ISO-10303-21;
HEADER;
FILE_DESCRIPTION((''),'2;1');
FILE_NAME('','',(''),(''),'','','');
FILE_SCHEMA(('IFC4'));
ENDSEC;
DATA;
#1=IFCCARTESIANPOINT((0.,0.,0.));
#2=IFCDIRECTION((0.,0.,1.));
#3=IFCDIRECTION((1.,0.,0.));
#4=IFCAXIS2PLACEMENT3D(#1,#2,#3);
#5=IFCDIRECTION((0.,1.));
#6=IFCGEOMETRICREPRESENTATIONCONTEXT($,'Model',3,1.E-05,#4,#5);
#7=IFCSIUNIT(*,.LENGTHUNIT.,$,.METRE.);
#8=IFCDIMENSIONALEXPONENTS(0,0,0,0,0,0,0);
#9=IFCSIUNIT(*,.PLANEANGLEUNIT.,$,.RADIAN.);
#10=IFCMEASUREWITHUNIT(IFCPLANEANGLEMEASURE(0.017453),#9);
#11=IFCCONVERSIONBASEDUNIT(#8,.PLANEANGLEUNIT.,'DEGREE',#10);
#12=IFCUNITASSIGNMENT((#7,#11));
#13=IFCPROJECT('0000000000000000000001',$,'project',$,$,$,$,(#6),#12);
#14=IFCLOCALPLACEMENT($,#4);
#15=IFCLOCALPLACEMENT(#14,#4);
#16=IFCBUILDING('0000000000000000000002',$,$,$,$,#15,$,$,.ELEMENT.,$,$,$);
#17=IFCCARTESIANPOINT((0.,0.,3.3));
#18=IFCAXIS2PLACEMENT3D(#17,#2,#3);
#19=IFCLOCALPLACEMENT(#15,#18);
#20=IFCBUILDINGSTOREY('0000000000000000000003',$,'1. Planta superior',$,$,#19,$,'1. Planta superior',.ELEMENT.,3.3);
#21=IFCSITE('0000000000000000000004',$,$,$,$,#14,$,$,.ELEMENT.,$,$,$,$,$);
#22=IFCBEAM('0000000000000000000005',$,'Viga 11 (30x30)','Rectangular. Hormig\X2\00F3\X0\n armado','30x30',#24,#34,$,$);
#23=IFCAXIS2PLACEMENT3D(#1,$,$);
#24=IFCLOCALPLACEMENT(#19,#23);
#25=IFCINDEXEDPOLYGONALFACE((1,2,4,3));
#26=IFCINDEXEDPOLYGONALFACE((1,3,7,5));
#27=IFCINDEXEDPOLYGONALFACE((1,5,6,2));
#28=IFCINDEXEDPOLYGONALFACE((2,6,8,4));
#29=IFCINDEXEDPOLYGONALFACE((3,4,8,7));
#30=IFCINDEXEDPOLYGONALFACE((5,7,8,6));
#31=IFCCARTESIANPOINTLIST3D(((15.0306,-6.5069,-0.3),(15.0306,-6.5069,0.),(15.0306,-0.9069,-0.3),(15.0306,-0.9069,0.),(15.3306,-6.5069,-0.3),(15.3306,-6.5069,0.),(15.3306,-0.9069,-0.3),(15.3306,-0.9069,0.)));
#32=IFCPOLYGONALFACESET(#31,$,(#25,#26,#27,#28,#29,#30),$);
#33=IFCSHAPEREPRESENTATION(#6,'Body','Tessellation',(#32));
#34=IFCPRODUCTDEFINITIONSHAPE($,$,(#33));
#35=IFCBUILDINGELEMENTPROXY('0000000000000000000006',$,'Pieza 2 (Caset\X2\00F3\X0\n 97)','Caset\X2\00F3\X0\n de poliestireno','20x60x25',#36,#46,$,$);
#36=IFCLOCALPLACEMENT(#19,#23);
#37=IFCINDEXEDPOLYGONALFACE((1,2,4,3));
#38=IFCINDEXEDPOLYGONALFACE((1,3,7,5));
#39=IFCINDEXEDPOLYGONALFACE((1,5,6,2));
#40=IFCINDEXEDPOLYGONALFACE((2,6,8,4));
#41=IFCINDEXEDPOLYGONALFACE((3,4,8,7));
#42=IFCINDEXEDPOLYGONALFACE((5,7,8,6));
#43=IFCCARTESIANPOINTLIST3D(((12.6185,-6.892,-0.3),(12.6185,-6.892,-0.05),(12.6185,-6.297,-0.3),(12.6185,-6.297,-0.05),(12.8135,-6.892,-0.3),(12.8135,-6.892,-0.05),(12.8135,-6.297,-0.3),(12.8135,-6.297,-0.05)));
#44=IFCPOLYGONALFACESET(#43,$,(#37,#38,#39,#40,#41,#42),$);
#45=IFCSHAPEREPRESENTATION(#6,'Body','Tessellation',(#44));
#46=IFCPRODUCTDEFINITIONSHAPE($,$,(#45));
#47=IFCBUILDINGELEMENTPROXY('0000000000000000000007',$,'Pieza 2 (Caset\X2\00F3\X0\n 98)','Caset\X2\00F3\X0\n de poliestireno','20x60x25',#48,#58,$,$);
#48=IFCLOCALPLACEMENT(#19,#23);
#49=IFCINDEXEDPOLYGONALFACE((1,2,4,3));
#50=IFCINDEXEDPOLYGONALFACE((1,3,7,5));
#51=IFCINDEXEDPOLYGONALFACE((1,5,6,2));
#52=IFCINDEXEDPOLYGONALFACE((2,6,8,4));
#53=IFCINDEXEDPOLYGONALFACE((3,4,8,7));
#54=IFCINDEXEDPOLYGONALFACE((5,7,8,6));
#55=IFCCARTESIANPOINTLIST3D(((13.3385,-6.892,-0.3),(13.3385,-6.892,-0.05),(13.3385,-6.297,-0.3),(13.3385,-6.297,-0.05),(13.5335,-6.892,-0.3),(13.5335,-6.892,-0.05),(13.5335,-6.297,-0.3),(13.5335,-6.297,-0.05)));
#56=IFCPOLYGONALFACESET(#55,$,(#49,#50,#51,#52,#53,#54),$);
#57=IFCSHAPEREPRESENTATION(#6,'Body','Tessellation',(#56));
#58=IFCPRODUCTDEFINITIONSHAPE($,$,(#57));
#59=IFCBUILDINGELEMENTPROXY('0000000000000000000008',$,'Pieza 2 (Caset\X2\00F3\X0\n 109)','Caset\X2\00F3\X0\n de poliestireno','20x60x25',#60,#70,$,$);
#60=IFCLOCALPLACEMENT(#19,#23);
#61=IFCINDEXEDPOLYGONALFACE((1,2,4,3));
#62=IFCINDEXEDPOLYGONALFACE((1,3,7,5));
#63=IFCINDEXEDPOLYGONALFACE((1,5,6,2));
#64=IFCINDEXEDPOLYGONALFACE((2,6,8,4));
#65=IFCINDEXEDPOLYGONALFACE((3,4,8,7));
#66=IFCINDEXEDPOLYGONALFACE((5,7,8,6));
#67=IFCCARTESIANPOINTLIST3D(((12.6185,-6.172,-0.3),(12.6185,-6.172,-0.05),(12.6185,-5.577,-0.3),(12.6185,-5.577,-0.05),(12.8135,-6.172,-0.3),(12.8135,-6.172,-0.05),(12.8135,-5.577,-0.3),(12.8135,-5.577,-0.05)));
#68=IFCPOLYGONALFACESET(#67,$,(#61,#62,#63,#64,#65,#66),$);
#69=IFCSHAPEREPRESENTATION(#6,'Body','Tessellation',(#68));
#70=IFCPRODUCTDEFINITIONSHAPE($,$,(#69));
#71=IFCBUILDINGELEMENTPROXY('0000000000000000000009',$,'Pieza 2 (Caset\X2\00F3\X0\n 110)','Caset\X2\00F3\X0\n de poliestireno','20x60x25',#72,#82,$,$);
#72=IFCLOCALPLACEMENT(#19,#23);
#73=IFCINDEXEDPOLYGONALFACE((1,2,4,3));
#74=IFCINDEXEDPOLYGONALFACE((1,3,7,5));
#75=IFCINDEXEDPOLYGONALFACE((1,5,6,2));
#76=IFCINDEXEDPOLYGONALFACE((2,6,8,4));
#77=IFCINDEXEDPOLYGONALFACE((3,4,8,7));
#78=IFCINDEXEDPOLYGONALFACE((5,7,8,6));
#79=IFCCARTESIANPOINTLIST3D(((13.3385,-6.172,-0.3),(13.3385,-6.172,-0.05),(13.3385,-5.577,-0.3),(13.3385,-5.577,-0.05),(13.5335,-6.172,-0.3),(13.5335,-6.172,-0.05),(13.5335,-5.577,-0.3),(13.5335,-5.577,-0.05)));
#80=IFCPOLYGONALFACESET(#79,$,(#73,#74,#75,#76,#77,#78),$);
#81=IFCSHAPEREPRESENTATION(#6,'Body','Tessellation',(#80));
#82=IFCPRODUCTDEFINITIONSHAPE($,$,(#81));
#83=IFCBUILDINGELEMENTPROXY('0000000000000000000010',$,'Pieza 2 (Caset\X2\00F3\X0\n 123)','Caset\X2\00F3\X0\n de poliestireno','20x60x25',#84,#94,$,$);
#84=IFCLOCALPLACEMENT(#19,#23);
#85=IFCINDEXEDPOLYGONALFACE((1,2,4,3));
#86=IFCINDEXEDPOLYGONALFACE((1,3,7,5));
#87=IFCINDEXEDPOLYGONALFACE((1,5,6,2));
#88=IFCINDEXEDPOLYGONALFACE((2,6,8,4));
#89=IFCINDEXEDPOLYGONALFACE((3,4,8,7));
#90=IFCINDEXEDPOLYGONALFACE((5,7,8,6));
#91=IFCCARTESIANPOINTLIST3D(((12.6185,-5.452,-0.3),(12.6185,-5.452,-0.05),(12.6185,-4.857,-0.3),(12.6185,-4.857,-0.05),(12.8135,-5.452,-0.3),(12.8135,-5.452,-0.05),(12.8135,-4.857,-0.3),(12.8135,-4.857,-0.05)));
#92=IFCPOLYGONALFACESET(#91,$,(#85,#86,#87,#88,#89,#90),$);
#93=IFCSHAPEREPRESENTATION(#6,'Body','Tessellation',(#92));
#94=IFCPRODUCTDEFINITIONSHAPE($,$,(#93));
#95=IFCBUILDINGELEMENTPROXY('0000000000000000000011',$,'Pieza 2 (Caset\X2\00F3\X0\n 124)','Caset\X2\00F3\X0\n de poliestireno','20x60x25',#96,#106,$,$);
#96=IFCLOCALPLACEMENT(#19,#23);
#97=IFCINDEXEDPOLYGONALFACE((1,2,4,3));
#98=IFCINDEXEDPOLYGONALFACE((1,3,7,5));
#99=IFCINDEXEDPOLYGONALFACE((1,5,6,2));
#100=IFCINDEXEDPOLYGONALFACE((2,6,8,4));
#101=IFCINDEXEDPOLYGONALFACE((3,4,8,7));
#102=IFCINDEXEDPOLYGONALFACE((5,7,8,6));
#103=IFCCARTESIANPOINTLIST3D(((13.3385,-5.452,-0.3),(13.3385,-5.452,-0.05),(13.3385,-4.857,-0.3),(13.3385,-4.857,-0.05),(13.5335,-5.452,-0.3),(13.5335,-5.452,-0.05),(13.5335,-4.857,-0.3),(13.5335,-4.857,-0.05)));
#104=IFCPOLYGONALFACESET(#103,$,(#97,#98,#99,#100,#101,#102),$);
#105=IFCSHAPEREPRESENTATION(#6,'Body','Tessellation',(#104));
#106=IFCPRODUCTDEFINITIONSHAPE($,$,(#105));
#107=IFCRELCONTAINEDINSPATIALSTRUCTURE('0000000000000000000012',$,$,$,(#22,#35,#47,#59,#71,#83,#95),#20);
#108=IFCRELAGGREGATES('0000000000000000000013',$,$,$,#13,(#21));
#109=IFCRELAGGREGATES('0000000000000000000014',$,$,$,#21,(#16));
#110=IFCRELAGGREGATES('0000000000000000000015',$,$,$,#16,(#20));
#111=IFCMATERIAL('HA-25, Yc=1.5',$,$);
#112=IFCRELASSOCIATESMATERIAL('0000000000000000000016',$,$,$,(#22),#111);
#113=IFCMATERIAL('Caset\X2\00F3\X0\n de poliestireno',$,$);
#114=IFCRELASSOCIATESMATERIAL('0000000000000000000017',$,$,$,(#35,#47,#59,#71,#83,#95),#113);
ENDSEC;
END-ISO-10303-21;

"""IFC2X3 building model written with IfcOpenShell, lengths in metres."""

from ifc_helpers import new_model, entity, si_unit, converted_unit, direction, frame, frame_2d, origin_with_axes, origin_2d_with_axis, place, context, project, spatial, rectangle, extrude, source, transform, mapped, material, element, save


model = new_model("IFC2X3")

# Units and contexts
model_context = context("Model", 3, precision=1e-05, world=origin_with_axes(), true_north=direction((0.0, 1.0)))
ifc_project = project(units=[si_unit("LENGTHUNIT", "METRE"), converted_unit("PLANEANGLEUNIT", "DEGREE", entity("IfcPlaneAngleMeasure", 0.017453), si_unit("PLANEANGLEUNIT", "RADIAN"), dimensions=[0, 0, 0, 0, 0, 0, 0])], contexts=[model_context])

# Site, building, storey
site_placement = place(None, origin_with_axes())
site = spatial("IfcSite", under=ifc_project, at=site_placement, CompositionType="ELEMENT")
building_placement = place(site_placement, origin_with_axes())
building = spatial("IfcBuilding", under=site, at=building_placement, CompositionType="ELEMENT")
storey_placement = place(building_placement, frame((0.0, 0.0, 3.3), z_axis=(0.0, 0.0, 1.0), x_axis=(1.0, 0.0, 0.0)))
storey = spatial("IfcBuildingStorey", under=building, at=storey_placement, Name="1. Planta superior", LongName="1. Planta superior", CompositionType="ELEMENT", Elevation=3.3)

# Beam
ifc_material_1 = material(Name="HA-25, Yc=1.5")
beam_placement = place(storey_placement, frame((15.1806, -6.5069, 0.0), z_axis=(0.0, 1.0, 0.0), x_axis=(-1.0, 0.0, 0.0)))
element("IfcBeam", 1, at=beam_placement, inside=storey, material=ifc_material_1, Name="Viga 11 (30x30)", Description="Rectangular. Hormigón armado", ObjectType="30x30", context=model_context, shape_type="SweptSolid", body=[
    extrude(rectangle(XDim=0.3, YDim=0.3, at=frame_2d((0.0, -0.15), x_axis=(1.0, 0.0))), origin_with_axes(), (0.0, 0.0, 1.0), 5.6),
])

# Building element proxies
ifc_material_2 = material(Name="Casetón de poliestireno")
shared_shape = source(origin_with_axes(), model_context, "Body", "SweptSolid", [
    extrude(rectangle(XDim=0.195, YDim=0.25, at=origin_2d_with_axis()), origin_with_axes(), (0.0, 0.0, 1.0), 0.595),
])
placement_1 = place(storey_placement, frame((12.716, -6.892, -0.175), z_axis=(0.0, 1.0, 0.0), x_axis=(-1.0, 0.0, 0.0)))
for number, where, z_axis, x_axis, name in (
    (2, (0.0, 0.0, 0.0), (0.0, 0.0, 1.0), (1.0, 0.0, 0.0), "Pieza 2 (Casetón 97)"),
):
    element("IfcBuildingElementProxy", number, at=place(placement_1, frame(where, z_axis=z_axis, x_axis=x_axis)), inside=storey, material=ifc_material_2, Name=name, Description="Casetón de poliestireno", ObjectType="20x60x25", context=model_context, shape_type="MappedRepresentation", body=[
        mapped(shared_shape, transform((0.0, 0.0, 0.0), x_axis=(1.0, 0.0, 0.0), y_axis=(0.0, 1.0, 0.0), z_axis=(0.0, 0.0, 1.0))),
    ])
placement_2 = place(storey_placement, frame((13.436, -6.892, -0.175), z_axis=(0.0, 1.0, 0.0), x_axis=(-1.0, 0.0, 0.0)))
for number, where, z_axis, x_axis, name in (
    (3, (0.0, 0.0, 0.0), (0.0, 0.0, 1.0), (1.0, 0.0, 0.0), "Pieza 2 (Casetón 98)"),
):
    element("IfcBuildingElementProxy", number, at=place(placement_2, frame(where, z_axis=z_axis, x_axis=x_axis)), inside=storey, material=ifc_material_2, Name=name, Description="Casetón de poliestireno", ObjectType="20x60x25", context=model_context, shape_type="MappedRepresentation", body=[
        mapped(shared_shape, transform((0.0, 0.0, 0.0), x_axis=(1.0, 0.0, 0.0), y_axis=(0.0, 1.0, 0.0), z_axis=(0.0, 0.0, 1.0))),
    ])
placement_3 = place(storey_placement, frame((12.716, -6.172, -0.175), z_axis=(0.0, 1.0, 0.0), x_axis=(-1.0, 0.0, 0.0)))
for number, where, z_axis, x_axis, name in (
    (4, (0.0, 0.0, 0.0), (0.0, 0.0, 1.0), (1.0, 0.0, 0.0), "Pieza 2 (Casetón 109)"),
):
    element("IfcBuildingElementProxy", number, at=place(placement_3, frame(where, z_axis=z_axis, x_axis=x_axis)), inside=storey, material=ifc_material_2, Name=name, Description="Casetón de poliestireno", ObjectType="20x60x25", context=model_context, shape_type="MappedRepresentation", body=[
        mapped(shared_shape, transform((0.0, 0.0, 0.0), x_axis=(1.0, 0.0, 0.0), y_axis=(0.0, 1.0, 0.0), z_axis=(0.0, 0.0, 1.0))),
    ])
placement_4 = place(storey_placement, frame((13.436, -6.172, -0.175), z_axis=(0.0, 1.0, 0.0), x_axis=(-1.0, 0.0, 0.0)))
for number, where, z_axis, x_axis, name in (
    (5, (0.0, 0.0, 0.0), (0.0, 0.0, 1.0), (1.0, 0.0, 0.0), "Pieza 2 (Casetón 110)"),
):
    element("IfcBuildingElementProxy", number, at=place(placement_4, frame(where, z_axis=z_axis, x_axis=x_axis)), inside=storey, material=ifc_material_2, Name=name, Description="Casetón de poliestireno", ObjectType="20x60x25", context=model_context, shape_type="MappedRepresentation", body=[
        mapped(shared_shape, transform((0.0, 0.0, 0.0), x_axis=(1.0, 0.0, 0.0), y_axis=(0.0, 1.0, 0.0), z_axis=(0.0, 0.0, 1.0))),
    ])
placement_5 = place(storey_placement, frame((12.716, -5.452, -0.175), z_axis=(0.0, 1.0, 0.0), x_axis=(-1.0, 0.0, 0.0)))
for number, where, z_axis, x_axis, name in (
    (6, (0.0, 0.0, 0.0), (0.0, 0.0, 1.0), (1.0, 0.0, 0.0), "Pieza 2 (Casetón 123)"),
):
    element("IfcBuildingElementProxy", number, at=place(placement_5, frame(where, z_axis=z_axis, x_axis=x_axis)), inside=storey, material=ifc_material_2, Name=name, Description="Casetón de poliestireno", ObjectType="20x60x25", context=model_context, shape_type="MappedRepresentation", body=[
        mapped(shared_shape, transform((0.0, 0.0, 0.0), x_axis=(1.0, 0.0, 0.0), y_axis=(0.0, 1.0, 0.0), z_axis=(0.0, 0.0, 1.0))),
    ])
placement_6 = place(storey_placement, frame((13.436, -5.452, -0.175), z_axis=(0.0, 1.0, 0.0), x_axis=(-1.0, 0.0, 0.0)))
for number, where, z_axis, x_axis, name in (
    (7, (0.0, 0.0, 0.0), (0.0, 0.0, 1.0), (1.0, 0.0, 0.0), "Pieza 2 (Casetón 124)"),
):
    element("IfcBuildingElementProxy", number, at=place(placement_6, frame(where, z_axis=z_axis, x_axis=x_axis)), inside=storey, material=ifc_material_2, Name=name, Description="Casetón de poliestireno", ObjectType="20x60x25", context=model_context, shape_type="MappedRepresentation", body=[
        mapped(shared_shape, transform((0.0, 0.0, 0.0), x_axis=(1.0, 0.0, 0.0), y_axis=(0.0, 1.0, 0.0), z_axis=(0.0, 0.0, 1.0))),
    ])

save(model, "model.ifc")
